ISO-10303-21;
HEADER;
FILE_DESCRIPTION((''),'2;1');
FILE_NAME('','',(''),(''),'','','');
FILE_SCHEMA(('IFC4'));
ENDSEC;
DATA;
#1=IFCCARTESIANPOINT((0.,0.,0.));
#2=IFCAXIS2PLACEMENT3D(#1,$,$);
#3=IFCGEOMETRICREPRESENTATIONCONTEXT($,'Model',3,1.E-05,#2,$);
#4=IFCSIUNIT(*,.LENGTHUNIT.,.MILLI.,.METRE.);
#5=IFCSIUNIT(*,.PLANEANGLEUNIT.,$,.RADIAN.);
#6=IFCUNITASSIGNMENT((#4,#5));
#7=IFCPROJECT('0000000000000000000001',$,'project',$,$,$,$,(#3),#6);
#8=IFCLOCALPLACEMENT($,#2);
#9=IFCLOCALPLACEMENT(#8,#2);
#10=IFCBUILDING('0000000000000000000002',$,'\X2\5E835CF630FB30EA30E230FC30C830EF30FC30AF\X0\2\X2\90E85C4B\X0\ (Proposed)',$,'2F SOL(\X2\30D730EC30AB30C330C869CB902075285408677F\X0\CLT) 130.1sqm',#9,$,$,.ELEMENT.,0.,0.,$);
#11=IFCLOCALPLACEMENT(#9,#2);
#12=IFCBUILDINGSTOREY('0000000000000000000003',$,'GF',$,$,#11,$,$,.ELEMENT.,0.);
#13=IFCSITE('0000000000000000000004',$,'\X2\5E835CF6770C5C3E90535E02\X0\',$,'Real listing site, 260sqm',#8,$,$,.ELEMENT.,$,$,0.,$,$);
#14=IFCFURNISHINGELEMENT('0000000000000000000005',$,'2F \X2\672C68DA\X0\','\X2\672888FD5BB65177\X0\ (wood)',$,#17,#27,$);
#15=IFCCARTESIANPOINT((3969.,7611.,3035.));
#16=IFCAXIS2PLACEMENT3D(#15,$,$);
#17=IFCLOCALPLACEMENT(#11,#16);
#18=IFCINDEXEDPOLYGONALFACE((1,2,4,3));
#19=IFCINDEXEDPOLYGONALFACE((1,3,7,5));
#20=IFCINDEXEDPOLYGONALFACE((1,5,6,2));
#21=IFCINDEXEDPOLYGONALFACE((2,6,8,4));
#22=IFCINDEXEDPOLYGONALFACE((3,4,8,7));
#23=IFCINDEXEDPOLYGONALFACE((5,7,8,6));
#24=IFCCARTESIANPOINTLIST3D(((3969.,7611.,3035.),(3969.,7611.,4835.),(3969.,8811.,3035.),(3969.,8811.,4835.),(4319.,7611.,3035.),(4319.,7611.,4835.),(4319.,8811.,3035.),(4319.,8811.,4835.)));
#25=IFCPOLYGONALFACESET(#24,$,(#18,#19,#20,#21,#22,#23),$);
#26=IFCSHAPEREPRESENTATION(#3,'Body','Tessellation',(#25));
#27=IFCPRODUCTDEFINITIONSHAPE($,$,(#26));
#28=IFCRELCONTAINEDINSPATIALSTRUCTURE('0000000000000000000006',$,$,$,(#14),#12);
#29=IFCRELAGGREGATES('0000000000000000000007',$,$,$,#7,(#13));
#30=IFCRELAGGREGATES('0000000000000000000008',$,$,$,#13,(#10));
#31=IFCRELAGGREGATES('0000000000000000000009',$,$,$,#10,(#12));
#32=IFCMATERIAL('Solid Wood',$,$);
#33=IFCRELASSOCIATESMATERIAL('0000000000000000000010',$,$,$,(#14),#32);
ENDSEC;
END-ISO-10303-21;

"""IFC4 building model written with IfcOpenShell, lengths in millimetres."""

from ifc_helpers import new_model, si_unit, frame, frame_2d, origin, place, context, project, spatial, rectangle, extrude, material, element, save


model = new_model("IFC4")

# Units and contexts
model_context = context("Model", 3, precision=1e-05, world=origin())
ifc_project = project(units=[si_unit("LENGTHUNIT", "METRE", prefix="MILLI"), si_unit("PLANEANGLEUNIT", "RADIAN")], contexts=[model_context])

# Site, building, storey
site_placement = place(None, origin())
site = spatial("IfcSite", under=ifc_project, at=site_placement, Name="広島県尾道市", ObjectType="Real listing site, 260sqm", CompositionType="ELEMENT", RefElevation=0.0)
building_placement = place(site_placement, origin())
building = spatial("IfcBuilding", under=site, at=building_placement, Name="広島・リモートワーク2部屋 (Proposed)", ObjectType="2F SOL(プレカット構造用合板CLT) 130.1sqm", CompositionType="ELEMENT", ElevationOfRefHeight=0.0, ElevationOfTerrain=0.0)
storey_placement = place(building_placement, origin())
storey = spatial("IfcBuildingStorey", under=building, at=storey_placement, Name="GF", CompositionType="ELEMENT", Elevation=0.0)

# Shared definitions
ifc_material_1 = material(Name="Solid Wood")

# Furnishing element
furnishing_placement = place(storey_placement, frame((3969.0, 7611.0, 3035.0)))
element("IfcFurnishingElement", 1, at=furnishing_placement, inside=storey, material=ifc_material_1, Name="2F 本棚", Description="木製家具 (wood)", context=model_context, shape_type="SweptSolid", body=[
    extrude(rectangle(XDim=350.0, YDim=1200.0, at=frame_2d((175.0, 600.0))), frame((3969.0, 7611.0, 3035.0)), (0.0, 0.0, 1.0), 1800.0),
])

save(model, "model.ifc")
